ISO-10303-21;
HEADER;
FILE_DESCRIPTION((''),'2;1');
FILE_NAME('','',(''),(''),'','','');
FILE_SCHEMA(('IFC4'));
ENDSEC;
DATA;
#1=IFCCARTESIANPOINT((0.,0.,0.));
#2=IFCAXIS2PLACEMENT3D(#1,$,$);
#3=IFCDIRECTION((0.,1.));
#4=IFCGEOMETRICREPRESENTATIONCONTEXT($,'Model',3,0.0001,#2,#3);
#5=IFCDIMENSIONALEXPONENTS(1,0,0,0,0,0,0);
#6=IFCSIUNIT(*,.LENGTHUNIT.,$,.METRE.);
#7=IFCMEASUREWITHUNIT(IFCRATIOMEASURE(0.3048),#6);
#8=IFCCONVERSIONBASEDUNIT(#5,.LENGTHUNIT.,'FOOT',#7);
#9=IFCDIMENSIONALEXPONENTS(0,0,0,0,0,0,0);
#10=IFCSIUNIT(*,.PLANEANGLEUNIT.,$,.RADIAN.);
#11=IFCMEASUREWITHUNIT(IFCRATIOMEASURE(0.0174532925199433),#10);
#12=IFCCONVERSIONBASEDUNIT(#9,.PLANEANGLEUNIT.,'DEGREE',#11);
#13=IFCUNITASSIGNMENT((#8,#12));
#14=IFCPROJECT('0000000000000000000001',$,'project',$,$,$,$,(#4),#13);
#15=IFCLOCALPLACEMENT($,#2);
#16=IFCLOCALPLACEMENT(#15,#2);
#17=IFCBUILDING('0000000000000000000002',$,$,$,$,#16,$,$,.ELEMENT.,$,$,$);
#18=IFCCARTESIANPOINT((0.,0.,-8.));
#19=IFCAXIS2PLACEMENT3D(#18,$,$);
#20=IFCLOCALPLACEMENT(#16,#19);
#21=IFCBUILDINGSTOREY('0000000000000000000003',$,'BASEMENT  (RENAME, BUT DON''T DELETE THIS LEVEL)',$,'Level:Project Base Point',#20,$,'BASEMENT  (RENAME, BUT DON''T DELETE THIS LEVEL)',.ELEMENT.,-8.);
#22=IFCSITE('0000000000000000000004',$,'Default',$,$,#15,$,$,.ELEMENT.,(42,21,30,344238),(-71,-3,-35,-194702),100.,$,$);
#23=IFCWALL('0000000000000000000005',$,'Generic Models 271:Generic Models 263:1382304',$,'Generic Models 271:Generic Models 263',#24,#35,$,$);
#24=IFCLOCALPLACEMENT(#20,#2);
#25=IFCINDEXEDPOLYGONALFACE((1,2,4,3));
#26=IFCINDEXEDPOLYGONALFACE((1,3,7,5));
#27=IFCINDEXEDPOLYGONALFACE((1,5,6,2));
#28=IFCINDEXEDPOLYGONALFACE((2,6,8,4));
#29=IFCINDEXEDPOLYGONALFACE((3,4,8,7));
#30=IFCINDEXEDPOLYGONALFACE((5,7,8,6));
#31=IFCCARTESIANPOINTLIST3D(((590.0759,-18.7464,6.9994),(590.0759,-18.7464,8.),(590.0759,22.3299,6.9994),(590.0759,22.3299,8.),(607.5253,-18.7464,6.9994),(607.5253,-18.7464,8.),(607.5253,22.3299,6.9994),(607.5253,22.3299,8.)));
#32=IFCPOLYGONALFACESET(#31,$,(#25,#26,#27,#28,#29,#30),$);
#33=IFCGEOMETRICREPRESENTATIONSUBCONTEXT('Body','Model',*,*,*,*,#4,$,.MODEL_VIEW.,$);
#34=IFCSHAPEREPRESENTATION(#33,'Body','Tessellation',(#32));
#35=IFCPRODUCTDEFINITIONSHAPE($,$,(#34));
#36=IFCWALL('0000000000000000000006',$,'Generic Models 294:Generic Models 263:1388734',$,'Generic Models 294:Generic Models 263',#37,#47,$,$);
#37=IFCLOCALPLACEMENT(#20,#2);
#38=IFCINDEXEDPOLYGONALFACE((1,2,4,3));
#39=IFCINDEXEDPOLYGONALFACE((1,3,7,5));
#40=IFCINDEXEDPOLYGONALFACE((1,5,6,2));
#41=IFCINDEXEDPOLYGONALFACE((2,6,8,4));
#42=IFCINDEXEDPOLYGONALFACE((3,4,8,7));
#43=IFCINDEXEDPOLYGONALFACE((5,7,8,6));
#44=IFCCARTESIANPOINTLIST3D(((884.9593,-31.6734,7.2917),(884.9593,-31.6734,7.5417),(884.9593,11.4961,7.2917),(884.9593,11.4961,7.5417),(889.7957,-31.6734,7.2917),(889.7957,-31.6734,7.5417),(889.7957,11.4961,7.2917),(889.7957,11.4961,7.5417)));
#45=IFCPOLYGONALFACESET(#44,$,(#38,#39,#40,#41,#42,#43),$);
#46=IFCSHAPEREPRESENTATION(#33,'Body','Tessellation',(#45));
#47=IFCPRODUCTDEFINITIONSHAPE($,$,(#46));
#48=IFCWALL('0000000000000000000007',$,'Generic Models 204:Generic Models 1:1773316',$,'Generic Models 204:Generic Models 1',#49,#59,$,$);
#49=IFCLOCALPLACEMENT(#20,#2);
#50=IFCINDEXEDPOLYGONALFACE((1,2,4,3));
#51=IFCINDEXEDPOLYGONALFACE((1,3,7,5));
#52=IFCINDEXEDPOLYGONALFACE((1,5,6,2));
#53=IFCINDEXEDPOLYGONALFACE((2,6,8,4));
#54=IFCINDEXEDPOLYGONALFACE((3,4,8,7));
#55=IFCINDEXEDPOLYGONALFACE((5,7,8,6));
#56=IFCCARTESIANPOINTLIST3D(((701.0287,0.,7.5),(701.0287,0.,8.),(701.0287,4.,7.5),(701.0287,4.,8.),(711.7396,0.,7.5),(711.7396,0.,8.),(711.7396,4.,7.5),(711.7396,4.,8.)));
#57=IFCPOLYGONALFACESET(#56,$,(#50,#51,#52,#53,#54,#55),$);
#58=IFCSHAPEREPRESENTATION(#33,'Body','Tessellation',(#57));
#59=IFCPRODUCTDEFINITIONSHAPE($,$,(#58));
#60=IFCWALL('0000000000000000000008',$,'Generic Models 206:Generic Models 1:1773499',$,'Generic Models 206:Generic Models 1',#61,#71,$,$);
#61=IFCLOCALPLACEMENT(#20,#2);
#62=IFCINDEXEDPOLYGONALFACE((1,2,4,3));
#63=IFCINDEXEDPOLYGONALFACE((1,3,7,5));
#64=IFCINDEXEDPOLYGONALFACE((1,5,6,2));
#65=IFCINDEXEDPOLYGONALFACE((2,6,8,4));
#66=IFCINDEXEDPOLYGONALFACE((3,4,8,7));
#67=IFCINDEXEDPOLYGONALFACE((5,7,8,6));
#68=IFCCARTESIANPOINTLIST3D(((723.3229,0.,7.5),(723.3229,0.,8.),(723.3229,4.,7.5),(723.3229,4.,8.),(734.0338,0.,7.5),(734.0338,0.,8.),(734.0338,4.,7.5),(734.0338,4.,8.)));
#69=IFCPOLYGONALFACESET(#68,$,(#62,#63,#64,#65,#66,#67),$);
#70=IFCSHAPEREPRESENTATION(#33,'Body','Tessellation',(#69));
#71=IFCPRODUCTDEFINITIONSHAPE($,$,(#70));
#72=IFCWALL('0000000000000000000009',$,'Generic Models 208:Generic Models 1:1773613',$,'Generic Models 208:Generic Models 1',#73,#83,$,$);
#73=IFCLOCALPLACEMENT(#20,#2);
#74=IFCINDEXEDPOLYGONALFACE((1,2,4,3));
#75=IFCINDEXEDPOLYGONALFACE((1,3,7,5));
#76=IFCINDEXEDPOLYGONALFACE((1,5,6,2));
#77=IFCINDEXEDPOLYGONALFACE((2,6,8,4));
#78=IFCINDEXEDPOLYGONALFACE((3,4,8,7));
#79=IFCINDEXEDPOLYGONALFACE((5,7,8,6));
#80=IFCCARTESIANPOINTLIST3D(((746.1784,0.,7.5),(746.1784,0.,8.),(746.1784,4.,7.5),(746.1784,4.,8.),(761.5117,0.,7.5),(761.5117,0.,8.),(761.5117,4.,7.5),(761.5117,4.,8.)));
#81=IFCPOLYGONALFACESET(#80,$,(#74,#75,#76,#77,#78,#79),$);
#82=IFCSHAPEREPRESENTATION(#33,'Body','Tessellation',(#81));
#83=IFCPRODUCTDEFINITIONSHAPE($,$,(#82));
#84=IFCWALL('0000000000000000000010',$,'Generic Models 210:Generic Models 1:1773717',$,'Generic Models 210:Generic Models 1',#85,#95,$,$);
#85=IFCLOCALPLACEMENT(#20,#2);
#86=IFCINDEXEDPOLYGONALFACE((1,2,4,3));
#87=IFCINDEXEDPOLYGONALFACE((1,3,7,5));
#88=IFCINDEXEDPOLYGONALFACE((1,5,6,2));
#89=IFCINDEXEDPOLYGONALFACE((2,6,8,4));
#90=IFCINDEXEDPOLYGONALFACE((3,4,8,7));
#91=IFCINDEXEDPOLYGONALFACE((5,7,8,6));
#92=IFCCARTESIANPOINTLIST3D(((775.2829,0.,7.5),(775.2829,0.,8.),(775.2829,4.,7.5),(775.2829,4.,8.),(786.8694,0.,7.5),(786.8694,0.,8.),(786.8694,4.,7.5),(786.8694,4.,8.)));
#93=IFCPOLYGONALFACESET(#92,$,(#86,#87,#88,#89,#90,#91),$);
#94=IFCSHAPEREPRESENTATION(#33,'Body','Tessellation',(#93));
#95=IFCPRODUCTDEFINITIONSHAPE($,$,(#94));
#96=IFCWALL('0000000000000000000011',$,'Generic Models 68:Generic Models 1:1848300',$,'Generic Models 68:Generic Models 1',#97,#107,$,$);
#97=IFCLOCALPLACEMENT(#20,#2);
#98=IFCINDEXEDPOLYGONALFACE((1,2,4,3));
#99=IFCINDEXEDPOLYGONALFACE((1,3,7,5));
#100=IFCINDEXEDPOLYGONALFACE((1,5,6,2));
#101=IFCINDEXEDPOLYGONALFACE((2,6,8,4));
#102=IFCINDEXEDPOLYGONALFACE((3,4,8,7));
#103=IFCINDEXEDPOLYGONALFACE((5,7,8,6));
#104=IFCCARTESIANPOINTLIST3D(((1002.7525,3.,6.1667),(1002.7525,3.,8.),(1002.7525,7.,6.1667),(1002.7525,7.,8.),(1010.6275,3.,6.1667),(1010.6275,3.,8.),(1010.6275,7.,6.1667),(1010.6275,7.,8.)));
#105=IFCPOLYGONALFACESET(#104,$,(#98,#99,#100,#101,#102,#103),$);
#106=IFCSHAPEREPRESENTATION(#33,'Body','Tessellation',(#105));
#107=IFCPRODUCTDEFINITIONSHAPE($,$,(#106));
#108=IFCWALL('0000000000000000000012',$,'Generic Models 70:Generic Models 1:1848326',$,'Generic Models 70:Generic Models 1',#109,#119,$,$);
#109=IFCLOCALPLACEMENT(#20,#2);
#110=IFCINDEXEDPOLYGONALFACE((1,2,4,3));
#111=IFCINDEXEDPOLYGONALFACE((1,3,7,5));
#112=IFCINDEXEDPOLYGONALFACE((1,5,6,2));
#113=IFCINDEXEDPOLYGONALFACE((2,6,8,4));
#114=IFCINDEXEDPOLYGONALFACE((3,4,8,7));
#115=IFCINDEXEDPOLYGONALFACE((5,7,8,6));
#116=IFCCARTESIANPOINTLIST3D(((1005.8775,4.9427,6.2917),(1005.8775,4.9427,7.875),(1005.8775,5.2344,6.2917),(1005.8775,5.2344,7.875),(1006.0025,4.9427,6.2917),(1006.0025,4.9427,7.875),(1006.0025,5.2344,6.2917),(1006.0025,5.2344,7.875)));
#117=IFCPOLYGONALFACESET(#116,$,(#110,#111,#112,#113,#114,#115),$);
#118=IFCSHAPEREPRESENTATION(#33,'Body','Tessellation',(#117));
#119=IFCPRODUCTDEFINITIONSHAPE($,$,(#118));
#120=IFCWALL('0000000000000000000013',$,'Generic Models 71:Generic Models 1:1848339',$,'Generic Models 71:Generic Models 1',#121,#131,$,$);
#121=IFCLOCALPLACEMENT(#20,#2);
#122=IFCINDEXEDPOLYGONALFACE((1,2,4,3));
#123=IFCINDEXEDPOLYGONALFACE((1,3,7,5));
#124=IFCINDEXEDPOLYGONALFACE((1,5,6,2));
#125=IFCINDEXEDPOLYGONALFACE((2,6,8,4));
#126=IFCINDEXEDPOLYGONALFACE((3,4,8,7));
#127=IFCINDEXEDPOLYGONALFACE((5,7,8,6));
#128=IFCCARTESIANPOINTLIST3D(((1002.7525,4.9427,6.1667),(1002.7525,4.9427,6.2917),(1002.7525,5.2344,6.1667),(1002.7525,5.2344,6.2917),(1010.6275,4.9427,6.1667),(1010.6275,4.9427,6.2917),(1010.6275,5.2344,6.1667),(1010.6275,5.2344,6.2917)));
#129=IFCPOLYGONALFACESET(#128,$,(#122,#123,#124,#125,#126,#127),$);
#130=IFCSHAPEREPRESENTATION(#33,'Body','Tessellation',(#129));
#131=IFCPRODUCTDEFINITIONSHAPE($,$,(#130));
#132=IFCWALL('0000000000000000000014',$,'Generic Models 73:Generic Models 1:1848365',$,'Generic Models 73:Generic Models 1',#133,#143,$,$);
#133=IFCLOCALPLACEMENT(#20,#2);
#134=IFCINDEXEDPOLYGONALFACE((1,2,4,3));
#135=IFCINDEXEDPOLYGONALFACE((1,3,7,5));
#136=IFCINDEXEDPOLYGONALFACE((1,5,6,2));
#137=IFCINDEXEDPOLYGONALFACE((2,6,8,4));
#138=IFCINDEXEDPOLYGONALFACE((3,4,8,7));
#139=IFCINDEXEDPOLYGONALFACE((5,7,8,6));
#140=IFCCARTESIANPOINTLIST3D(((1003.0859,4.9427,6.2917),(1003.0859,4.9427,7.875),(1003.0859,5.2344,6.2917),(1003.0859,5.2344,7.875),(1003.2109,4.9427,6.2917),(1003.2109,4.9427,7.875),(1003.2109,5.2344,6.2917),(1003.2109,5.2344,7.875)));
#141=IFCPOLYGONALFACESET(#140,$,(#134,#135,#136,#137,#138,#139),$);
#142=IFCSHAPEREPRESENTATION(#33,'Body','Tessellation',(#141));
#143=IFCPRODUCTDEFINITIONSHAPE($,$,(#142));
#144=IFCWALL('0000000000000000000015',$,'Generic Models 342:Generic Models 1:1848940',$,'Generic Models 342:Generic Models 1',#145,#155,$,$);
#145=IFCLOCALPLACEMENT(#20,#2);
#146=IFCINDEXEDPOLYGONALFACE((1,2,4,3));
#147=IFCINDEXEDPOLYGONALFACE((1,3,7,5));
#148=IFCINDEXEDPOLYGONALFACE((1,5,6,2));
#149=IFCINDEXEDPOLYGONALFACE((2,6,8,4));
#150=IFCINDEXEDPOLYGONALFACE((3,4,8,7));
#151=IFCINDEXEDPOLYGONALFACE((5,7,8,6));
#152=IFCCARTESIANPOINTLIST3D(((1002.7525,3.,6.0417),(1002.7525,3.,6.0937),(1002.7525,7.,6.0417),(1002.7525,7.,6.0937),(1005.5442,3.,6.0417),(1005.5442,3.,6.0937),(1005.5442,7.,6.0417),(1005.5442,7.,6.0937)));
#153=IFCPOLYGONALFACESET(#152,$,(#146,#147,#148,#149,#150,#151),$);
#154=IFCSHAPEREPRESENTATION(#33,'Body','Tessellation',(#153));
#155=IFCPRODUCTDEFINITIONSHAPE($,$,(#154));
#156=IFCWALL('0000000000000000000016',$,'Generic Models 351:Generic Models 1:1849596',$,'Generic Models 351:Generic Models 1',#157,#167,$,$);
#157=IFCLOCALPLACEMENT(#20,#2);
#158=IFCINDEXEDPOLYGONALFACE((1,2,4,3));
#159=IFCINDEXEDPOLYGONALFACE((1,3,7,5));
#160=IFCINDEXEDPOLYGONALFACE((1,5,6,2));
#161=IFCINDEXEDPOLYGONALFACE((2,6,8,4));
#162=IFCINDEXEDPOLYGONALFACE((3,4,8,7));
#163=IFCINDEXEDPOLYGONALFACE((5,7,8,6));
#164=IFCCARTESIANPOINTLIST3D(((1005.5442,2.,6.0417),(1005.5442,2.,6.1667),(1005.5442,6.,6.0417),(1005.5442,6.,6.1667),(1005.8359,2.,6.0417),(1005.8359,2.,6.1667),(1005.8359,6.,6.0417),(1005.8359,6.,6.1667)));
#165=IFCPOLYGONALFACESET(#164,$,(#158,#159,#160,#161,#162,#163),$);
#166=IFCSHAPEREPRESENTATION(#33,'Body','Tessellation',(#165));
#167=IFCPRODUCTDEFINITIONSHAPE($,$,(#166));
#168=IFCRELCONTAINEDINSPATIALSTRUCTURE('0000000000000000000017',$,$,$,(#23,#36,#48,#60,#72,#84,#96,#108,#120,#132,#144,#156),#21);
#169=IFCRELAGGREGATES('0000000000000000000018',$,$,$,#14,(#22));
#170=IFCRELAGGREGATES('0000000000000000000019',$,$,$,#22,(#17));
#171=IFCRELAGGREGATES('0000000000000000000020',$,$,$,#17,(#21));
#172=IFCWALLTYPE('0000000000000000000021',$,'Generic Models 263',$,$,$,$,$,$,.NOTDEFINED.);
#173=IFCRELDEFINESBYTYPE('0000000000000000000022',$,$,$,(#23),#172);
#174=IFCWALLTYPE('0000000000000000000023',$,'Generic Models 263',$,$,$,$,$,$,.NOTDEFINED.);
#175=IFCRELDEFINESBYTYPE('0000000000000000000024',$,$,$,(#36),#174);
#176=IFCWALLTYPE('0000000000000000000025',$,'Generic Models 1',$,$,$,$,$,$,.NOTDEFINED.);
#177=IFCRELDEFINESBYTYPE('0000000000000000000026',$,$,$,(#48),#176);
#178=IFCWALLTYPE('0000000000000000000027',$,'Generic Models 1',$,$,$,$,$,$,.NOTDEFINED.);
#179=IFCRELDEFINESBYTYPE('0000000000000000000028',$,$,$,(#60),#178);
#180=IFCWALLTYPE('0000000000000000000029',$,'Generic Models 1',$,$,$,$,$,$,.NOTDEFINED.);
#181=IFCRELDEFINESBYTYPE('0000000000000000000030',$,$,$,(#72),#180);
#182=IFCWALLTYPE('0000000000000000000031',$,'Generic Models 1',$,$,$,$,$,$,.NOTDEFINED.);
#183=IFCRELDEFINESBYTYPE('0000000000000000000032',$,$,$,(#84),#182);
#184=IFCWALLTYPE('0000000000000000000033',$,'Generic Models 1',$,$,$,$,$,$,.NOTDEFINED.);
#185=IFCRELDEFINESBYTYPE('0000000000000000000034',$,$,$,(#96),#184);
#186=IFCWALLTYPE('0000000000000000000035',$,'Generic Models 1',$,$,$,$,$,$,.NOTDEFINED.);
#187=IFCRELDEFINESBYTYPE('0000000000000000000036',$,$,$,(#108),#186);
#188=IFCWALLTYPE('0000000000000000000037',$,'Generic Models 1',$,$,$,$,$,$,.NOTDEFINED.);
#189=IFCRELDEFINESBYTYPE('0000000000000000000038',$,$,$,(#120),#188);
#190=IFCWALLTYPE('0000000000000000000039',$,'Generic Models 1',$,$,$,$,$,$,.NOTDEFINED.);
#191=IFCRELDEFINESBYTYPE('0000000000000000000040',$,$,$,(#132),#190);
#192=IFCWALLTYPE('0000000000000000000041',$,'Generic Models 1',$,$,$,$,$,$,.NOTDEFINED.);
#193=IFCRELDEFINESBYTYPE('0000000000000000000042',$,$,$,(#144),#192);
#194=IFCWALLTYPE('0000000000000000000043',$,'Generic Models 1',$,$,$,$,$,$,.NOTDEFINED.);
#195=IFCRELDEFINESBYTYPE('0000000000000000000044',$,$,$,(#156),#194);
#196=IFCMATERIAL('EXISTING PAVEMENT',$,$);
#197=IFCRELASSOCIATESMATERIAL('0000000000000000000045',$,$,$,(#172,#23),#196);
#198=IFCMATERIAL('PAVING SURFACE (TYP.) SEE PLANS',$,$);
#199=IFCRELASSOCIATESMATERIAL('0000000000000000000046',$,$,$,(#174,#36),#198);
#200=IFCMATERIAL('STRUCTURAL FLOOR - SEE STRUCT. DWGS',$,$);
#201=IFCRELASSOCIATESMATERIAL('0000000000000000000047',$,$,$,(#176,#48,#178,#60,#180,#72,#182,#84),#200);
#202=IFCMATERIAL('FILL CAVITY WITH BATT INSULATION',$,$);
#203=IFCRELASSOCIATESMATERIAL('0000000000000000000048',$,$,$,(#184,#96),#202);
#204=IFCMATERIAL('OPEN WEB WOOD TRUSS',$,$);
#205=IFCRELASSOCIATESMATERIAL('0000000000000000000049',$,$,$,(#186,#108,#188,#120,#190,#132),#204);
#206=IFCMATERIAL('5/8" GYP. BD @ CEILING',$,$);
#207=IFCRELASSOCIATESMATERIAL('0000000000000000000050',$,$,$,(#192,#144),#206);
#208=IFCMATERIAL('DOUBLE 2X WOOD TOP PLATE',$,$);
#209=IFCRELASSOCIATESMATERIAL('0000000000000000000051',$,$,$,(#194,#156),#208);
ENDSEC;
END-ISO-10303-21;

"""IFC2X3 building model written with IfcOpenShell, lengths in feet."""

from ifc_helpers import new_model, entity, si_unit, converted_unit, direction, frame, frame_2d, origin, origin_2d_with_axis, place, context, subcontext, project, spatial, rectangle, extrude, material, type_object, element, save


model = new_model("IFC2X3")

# Units and contexts
model_context = context("Model", 3, precision=0.0001, world=origin(), true_north=direction((0.0, 1.0)))
body_context = subcontext(model_context, "Body", "Model", "MODEL_VIEW")
ifc_project = project(units=[converted_unit("LENGTHUNIT", "FOOT", entity("IfcRatioMeasure", 0.3048), si_unit("LENGTHUNIT", "METRE"), dimensions=[1, 0, 0, 0, 0, 0, 0]), converted_unit("PLANEANGLEUNIT", "DEGREE", entity("IfcRatioMeasure", 0.0174532925199433), si_unit("PLANEANGLEUNIT", "RADIAN"), dimensions=[0, 0, 0, 0, 0, 0, 0])], contexts=[model_context])

# Site, building, storey
site_placement = place(None, origin())
site = spatial("IfcSite", under=ifc_project, at=site_placement, Name="Default", CompositionType="ELEMENT", RefLatitude=(42, 21, 30, 344238), RefLongitude=(-71, -3, -35, -194702), RefElevation=100.0)
building_placement = place(site_placement, origin())
building = spatial("IfcBuilding", under=site, at=building_placement, CompositionType="ELEMENT")
storey_placement = place(building_placement, frame((0.0, 0.0, -8.0)))
storey = spatial("IfcBuildingStorey", under=building, at=storey_placement, Name="BASEMENT  (RENAME, BUT DON'T DELETE THIS LEVEL)", ObjectType="Level:Project Base Point", LongName="BASEMENT  (RENAME, BUT DON'T DELETE THIS LEVEL)", CompositionType="ELEMENT", Elevation=-8.0)

# Walls
ifc_material_1 = material(Name="EXISTING PAVEMENT")
wall_type_1 = type_object("IfcWallType", Name="Generic Models 263", PredefinedType="NOTDEFINED", material=ifc_material_1)
wall_1_placement = place(storey_placement, frame((590.0759, -18.7464, 6.9994), z_axis=(0.0, 0.0, 1.0), x_axis=(0.0, 1.0, 0.0)))
element("IfcWall", 1, at=wall_1_placement, inside=storey, type_object=wall_type_1, material=ifc_material_1, Name="Generic Models 271:Generic Models 263:1382304", ObjectType="Generic Models 271:Generic Models 263", context=body_context, shape_type="SweptSolid", body=[
    extrude(rectangle(XDim=41.0763, YDim=17.4494, at=origin_2d_with_axis()), frame((20.5382, -8.7247, 0.0)), (0.0, 0.0, 1.0), 1.0006),
])
ifc_material_2 = material(Name="PAVING SURFACE (TYP.) SEE PLANS")
wall_type_2 = type_object("IfcWallType", Name="Generic Models 263", PredefinedType="NOTDEFINED", material=ifc_material_2)
wall_2_placement = place(storey_placement, frame((884.9593, -31.6734, 7.2917), z_axis=(0.0, 0.0, 1.0), x_axis=(0.0, 1.0, 0.0)))
element("IfcWall", 2, at=wall_2_placement, inside=storey, type_object=wall_type_2, material=ifc_material_2, Name="Generic Models 294:Generic Models 263:1388734", ObjectType="Generic Models 294:Generic Models 263", context=body_context, shape_type="SweptSolid", body=[
    extrude(rectangle(XDim=43.1695, YDim=4.8364, at=origin_2d_with_axis()), frame((21.5848, -2.4182, 0.0)), (0.0, 0.0, 1.0), 0.25),
])
ifc_material_3 = material(Name="STRUCTURAL FLOOR - SEE STRUCT. DWGS")
wall_type_3 = type_object("IfcWallType", Name="Generic Models 1", PredefinedType="NOTDEFINED", material=ifc_material_3)
wall_3_placement = place(storey_placement, frame((701.0287, 0.0, 7.5)))
element("IfcWall", 3, at=wall_3_placement, inside=storey, type_object=wall_type_3, material=ifc_material_3, Name="Generic Models 204:Generic Models 1:1773316", ObjectType="Generic Models 204:Generic Models 1", context=body_context, shape_type="SweptSolid", body=[
    extrude(rectangle(XDim=4.0, YDim=10.7109, at=frame_2d((0.0, 0.0), x_axis=(1.0, 0.0))), frame((5.3554, 2.0, 0.0), z_axis=(0.0, 0.0, 1.0), x_axis=(0.0, 1.0, 0.0)), (0.0, 0.0, 1.0), 0.5),
])
wall_type_4 = type_object("IfcWallType", Name="Generic Models 1", PredefinedType="NOTDEFINED", material=ifc_material_3)
wall_4_placement = place(storey_placement, frame((723.3229, 0.0, 7.5)))
element("IfcWall", 4, at=wall_4_placement, inside=storey, type_object=wall_type_4, material=ifc_material_3, Name="Generic Models 206:Generic Models 1:1773499", ObjectType="Generic Models 206:Generic Models 1", context=body_context, shape_type="SweptSolid", body=[
    extrude(rectangle(XDim=4.0, YDim=10.7109, at=frame_2d((0.0, 0.0), x_axis=(1.0, 0.0))), frame((5.3554, 2.0, 0.0), z_axis=(0.0, 0.0, 1.0), x_axis=(0.0, 1.0, 0.0)), (0.0, 0.0, 1.0), 0.5),
])
wall_type_5 = type_object("IfcWallType", Name="Generic Models 1", PredefinedType="NOTDEFINED", material=ifc_material_3)
wall_5_placement = place(storey_placement, frame((746.1784, 0.0, 7.5)))
element("IfcWall", 5, at=wall_5_placement, inside=storey, type_object=wall_type_5, material=ifc_material_3, Name="Generic Models 208:Generic Models 1:1773613", ObjectType="Generic Models 208:Generic Models 1", context=body_context, shape_type="SweptSolid", body=[
    extrude(rectangle(XDim=4.0, YDim=15.3333, at=frame_2d((0.0, 0.0), x_axis=(1.0, 0.0))), frame((7.6667, 2.0, 0.0), z_axis=(0.0, 0.0, 1.0), x_axis=(0.0, 1.0, 0.0)), (0.0, 0.0, 1.0), 0.5),
])
wall_type_6 = type_object("IfcWallType", Name="Generic Models 1", PredefinedType="NOTDEFINED", material=ifc_material_3)
wall_6_placement = place(storey_placement, frame((775.2829, 0.0, 7.5)))
element("IfcWall", 6, at=wall_6_placement, inside=storey, type_object=wall_type_6, material=ifc_material_3, Name="Generic Models 210:Generic Models 1:1773717", ObjectType="Generic Models 210:Generic Models 1", context=body_context, shape_type="SweptSolid", body=[
    extrude(rectangle(XDim=4.0, YDim=11.5865, at=frame_2d((0.0, 0.0), x_axis=(1.0, 0.0))), frame((5.7933, 2.0, 0.0), z_axis=(0.0, 0.0, 1.0), x_axis=(0.0, 1.0, 0.0)), (0.0, 0.0, 1.0), 0.5),
])
ifc_material_4 = material(Name="FILL CAVITY WITH BATT INSULATION")
wall_type_7 = type_object("IfcWallType", Name="Generic Models 1", PredefinedType="NOTDEFINED", material=ifc_material_4)
wall_7_placement = place(storey_placement, frame((1002.7525, 3.0, 6.1667)))
element("IfcWall", 7, at=wall_7_placement, inside=storey, type_object=wall_type_7, material=ifc_material_4, Name="Generic Models 68:Generic Models 1:1848300", ObjectType="Generic Models 68:Generic Models 1", context=body_context, shape_type="SweptSolid", body=[
    extrude(rectangle(XDim=4.0, YDim=7.875, at=frame_2d((0.0, 0.0), x_axis=(1.0, 0.0))), frame((3.9375, 2.0, 0.0), z_axis=(0.0, 0.0, 1.0), x_axis=(0.0, 1.0, 0.0)), (0.0, 0.0, 1.0), 1.8333),
])
ifc_material_5 = material(Name="OPEN WEB WOOD TRUSS")
wall_type_8 = type_object("IfcWallType", Name="Generic Models 1", PredefinedType="NOTDEFINED", material=ifc_material_5)
wall_8_placement = place(storey_placement, frame((1005.8775, 4.9427, 6.2917), z_axis=(0.0, 0.0, 1.0), x_axis=(0.0, 1.0, 0.0)))
element("IfcWall", 8, at=wall_8_placement, inside=storey, type_object=wall_type_8, material=ifc_material_5, Name="Generic Models 70:Generic Models 1:1848326", ObjectType="Generic Models 70:Generic Models 1", context=body_context, shape_type="SweptSolid", body=[
    extrude(rectangle(XDim=0.2917, YDim=0.125, at=origin_2d_with_axis()), frame((0.1458, -0.0625, 0.0)), (0.0, 0.0, 1.0), 1.5833),
])
wall_type_9 = type_object("IfcWallType", Name="Generic Models 1", PredefinedType="NOTDEFINED", material=ifc_material_5)
wall_9_placement = place(storey_placement, frame((1002.7525, 4.9427, 6.1667)))
element("IfcWall", 9, at=wall_9_placement, inside=storey, type_object=wall_type_9, material=ifc_material_5, Name="Generic Models 71:Generic Models 1:1848339", ObjectType="Generic Models 71:Generic Models 1", context=body_context, shape_type="SweptSolid", body=[
    extrude(rectangle(XDim=0.2917, YDim=7.875, at=origin_2d_with_axis()), frame((3.9375, 0.1458, 0.0), z_axis=(0.0, 0.0, 1.0), x_axis=(0.0, 1.0, 0.0)), (0.0, 0.0, 1.0), 0.125),
])
wall_type_10 = type_object("IfcWallType", Name="Generic Models 1", PredefinedType="NOTDEFINED", material=ifc_material_5)
wall_10_placement = place(storey_placement, frame((1003.0859, 4.9427, 6.2917), z_axis=(0.0, 0.0, 1.0), x_axis=(0.0, 1.0, 0.0)))
element("IfcWall", 10, at=wall_10_placement, inside=storey, type_object=wall_type_10, material=ifc_material_5, Name="Generic Models 73:Generic Models 1:1848365", ObjectType="Generic Models 73:Generic Models 1", context=body_context, shape_type="SweptSolid", body=[
    extrude(rectangle(XDim=0.2917, YDim=0.125, at=origin_2d_with_axis()), frame((0.1458, -0.0625, 0.0)), (0.0, 0.0, 1.0), 1.5833),
])
ifc_material_6 = material(Name="5/8\" GYP. BD @ CEILING")
wall_type_11 = type_object("IfcWallType", Name="Generic Models 1", PredefinedType="NOTDEFINED", material=ifc_material_6)
wall_11_placement = place(storey_placement, frame((1002.7525, 3.0, 6.0417), z_axis=(0.0, 0.0, 1.0), x_axis=(0.0, 1.0, 0.0)))
element("IfcWall", 11, at=wall_11_placement, inside=storey, type_object=wall_type_11, material=ifc_material_6, Name="Generic Models 342:Generic Models 1:1848940", ObjectType="Generic Models 342:Generic Models 1", context=body_context, shape_type="SweptSolid", body=[
    extrude(rectangle(XDim=4.0, YDim=2.7917, at=frame_2d((0.0, 0.0), x_axis=(1.0, 0.0))), frame((2.0, -1.3958, 0.0)), (0.0, 0.0, 1.0), 0.0521),
])
ifc_material_7 = material(Name="DOUBLE 2X WOOD TOP PLATE")
wall_type_12 = type_object("IfcWallType", Name="Generic Models 1", PredefinedType="NOTDEFINED", material=ifc_material_7)
wall_12_placement = place(storey_placement, frame((1005.5442, 2.0, 6.0417), z_axis=(0.0, 0.0, 1.0), x_axis=(0.0, 1.0, 0.0)))
element("IfcWall", 12, at=wall_12_placement, inside=storey, type_object=wall_type_12, material=ifc_material_7, Name="Generic Models 351:Generic Models 1:1849596", ObjectType="Generic Models 351:Generic Models 1", context=body_context, shape_type="SweptSolid", body=[
    extrude(rectangle(XDim=4.0, YDim=0.2917, at=frame_2d((0.0, 0.0), x_axis=(1.0, 0.0))), frame((2.0, -0.1458, 0.0)), (0.0, 0.0, 1.0), 0.125),
])

save(model, "model.ifc")
